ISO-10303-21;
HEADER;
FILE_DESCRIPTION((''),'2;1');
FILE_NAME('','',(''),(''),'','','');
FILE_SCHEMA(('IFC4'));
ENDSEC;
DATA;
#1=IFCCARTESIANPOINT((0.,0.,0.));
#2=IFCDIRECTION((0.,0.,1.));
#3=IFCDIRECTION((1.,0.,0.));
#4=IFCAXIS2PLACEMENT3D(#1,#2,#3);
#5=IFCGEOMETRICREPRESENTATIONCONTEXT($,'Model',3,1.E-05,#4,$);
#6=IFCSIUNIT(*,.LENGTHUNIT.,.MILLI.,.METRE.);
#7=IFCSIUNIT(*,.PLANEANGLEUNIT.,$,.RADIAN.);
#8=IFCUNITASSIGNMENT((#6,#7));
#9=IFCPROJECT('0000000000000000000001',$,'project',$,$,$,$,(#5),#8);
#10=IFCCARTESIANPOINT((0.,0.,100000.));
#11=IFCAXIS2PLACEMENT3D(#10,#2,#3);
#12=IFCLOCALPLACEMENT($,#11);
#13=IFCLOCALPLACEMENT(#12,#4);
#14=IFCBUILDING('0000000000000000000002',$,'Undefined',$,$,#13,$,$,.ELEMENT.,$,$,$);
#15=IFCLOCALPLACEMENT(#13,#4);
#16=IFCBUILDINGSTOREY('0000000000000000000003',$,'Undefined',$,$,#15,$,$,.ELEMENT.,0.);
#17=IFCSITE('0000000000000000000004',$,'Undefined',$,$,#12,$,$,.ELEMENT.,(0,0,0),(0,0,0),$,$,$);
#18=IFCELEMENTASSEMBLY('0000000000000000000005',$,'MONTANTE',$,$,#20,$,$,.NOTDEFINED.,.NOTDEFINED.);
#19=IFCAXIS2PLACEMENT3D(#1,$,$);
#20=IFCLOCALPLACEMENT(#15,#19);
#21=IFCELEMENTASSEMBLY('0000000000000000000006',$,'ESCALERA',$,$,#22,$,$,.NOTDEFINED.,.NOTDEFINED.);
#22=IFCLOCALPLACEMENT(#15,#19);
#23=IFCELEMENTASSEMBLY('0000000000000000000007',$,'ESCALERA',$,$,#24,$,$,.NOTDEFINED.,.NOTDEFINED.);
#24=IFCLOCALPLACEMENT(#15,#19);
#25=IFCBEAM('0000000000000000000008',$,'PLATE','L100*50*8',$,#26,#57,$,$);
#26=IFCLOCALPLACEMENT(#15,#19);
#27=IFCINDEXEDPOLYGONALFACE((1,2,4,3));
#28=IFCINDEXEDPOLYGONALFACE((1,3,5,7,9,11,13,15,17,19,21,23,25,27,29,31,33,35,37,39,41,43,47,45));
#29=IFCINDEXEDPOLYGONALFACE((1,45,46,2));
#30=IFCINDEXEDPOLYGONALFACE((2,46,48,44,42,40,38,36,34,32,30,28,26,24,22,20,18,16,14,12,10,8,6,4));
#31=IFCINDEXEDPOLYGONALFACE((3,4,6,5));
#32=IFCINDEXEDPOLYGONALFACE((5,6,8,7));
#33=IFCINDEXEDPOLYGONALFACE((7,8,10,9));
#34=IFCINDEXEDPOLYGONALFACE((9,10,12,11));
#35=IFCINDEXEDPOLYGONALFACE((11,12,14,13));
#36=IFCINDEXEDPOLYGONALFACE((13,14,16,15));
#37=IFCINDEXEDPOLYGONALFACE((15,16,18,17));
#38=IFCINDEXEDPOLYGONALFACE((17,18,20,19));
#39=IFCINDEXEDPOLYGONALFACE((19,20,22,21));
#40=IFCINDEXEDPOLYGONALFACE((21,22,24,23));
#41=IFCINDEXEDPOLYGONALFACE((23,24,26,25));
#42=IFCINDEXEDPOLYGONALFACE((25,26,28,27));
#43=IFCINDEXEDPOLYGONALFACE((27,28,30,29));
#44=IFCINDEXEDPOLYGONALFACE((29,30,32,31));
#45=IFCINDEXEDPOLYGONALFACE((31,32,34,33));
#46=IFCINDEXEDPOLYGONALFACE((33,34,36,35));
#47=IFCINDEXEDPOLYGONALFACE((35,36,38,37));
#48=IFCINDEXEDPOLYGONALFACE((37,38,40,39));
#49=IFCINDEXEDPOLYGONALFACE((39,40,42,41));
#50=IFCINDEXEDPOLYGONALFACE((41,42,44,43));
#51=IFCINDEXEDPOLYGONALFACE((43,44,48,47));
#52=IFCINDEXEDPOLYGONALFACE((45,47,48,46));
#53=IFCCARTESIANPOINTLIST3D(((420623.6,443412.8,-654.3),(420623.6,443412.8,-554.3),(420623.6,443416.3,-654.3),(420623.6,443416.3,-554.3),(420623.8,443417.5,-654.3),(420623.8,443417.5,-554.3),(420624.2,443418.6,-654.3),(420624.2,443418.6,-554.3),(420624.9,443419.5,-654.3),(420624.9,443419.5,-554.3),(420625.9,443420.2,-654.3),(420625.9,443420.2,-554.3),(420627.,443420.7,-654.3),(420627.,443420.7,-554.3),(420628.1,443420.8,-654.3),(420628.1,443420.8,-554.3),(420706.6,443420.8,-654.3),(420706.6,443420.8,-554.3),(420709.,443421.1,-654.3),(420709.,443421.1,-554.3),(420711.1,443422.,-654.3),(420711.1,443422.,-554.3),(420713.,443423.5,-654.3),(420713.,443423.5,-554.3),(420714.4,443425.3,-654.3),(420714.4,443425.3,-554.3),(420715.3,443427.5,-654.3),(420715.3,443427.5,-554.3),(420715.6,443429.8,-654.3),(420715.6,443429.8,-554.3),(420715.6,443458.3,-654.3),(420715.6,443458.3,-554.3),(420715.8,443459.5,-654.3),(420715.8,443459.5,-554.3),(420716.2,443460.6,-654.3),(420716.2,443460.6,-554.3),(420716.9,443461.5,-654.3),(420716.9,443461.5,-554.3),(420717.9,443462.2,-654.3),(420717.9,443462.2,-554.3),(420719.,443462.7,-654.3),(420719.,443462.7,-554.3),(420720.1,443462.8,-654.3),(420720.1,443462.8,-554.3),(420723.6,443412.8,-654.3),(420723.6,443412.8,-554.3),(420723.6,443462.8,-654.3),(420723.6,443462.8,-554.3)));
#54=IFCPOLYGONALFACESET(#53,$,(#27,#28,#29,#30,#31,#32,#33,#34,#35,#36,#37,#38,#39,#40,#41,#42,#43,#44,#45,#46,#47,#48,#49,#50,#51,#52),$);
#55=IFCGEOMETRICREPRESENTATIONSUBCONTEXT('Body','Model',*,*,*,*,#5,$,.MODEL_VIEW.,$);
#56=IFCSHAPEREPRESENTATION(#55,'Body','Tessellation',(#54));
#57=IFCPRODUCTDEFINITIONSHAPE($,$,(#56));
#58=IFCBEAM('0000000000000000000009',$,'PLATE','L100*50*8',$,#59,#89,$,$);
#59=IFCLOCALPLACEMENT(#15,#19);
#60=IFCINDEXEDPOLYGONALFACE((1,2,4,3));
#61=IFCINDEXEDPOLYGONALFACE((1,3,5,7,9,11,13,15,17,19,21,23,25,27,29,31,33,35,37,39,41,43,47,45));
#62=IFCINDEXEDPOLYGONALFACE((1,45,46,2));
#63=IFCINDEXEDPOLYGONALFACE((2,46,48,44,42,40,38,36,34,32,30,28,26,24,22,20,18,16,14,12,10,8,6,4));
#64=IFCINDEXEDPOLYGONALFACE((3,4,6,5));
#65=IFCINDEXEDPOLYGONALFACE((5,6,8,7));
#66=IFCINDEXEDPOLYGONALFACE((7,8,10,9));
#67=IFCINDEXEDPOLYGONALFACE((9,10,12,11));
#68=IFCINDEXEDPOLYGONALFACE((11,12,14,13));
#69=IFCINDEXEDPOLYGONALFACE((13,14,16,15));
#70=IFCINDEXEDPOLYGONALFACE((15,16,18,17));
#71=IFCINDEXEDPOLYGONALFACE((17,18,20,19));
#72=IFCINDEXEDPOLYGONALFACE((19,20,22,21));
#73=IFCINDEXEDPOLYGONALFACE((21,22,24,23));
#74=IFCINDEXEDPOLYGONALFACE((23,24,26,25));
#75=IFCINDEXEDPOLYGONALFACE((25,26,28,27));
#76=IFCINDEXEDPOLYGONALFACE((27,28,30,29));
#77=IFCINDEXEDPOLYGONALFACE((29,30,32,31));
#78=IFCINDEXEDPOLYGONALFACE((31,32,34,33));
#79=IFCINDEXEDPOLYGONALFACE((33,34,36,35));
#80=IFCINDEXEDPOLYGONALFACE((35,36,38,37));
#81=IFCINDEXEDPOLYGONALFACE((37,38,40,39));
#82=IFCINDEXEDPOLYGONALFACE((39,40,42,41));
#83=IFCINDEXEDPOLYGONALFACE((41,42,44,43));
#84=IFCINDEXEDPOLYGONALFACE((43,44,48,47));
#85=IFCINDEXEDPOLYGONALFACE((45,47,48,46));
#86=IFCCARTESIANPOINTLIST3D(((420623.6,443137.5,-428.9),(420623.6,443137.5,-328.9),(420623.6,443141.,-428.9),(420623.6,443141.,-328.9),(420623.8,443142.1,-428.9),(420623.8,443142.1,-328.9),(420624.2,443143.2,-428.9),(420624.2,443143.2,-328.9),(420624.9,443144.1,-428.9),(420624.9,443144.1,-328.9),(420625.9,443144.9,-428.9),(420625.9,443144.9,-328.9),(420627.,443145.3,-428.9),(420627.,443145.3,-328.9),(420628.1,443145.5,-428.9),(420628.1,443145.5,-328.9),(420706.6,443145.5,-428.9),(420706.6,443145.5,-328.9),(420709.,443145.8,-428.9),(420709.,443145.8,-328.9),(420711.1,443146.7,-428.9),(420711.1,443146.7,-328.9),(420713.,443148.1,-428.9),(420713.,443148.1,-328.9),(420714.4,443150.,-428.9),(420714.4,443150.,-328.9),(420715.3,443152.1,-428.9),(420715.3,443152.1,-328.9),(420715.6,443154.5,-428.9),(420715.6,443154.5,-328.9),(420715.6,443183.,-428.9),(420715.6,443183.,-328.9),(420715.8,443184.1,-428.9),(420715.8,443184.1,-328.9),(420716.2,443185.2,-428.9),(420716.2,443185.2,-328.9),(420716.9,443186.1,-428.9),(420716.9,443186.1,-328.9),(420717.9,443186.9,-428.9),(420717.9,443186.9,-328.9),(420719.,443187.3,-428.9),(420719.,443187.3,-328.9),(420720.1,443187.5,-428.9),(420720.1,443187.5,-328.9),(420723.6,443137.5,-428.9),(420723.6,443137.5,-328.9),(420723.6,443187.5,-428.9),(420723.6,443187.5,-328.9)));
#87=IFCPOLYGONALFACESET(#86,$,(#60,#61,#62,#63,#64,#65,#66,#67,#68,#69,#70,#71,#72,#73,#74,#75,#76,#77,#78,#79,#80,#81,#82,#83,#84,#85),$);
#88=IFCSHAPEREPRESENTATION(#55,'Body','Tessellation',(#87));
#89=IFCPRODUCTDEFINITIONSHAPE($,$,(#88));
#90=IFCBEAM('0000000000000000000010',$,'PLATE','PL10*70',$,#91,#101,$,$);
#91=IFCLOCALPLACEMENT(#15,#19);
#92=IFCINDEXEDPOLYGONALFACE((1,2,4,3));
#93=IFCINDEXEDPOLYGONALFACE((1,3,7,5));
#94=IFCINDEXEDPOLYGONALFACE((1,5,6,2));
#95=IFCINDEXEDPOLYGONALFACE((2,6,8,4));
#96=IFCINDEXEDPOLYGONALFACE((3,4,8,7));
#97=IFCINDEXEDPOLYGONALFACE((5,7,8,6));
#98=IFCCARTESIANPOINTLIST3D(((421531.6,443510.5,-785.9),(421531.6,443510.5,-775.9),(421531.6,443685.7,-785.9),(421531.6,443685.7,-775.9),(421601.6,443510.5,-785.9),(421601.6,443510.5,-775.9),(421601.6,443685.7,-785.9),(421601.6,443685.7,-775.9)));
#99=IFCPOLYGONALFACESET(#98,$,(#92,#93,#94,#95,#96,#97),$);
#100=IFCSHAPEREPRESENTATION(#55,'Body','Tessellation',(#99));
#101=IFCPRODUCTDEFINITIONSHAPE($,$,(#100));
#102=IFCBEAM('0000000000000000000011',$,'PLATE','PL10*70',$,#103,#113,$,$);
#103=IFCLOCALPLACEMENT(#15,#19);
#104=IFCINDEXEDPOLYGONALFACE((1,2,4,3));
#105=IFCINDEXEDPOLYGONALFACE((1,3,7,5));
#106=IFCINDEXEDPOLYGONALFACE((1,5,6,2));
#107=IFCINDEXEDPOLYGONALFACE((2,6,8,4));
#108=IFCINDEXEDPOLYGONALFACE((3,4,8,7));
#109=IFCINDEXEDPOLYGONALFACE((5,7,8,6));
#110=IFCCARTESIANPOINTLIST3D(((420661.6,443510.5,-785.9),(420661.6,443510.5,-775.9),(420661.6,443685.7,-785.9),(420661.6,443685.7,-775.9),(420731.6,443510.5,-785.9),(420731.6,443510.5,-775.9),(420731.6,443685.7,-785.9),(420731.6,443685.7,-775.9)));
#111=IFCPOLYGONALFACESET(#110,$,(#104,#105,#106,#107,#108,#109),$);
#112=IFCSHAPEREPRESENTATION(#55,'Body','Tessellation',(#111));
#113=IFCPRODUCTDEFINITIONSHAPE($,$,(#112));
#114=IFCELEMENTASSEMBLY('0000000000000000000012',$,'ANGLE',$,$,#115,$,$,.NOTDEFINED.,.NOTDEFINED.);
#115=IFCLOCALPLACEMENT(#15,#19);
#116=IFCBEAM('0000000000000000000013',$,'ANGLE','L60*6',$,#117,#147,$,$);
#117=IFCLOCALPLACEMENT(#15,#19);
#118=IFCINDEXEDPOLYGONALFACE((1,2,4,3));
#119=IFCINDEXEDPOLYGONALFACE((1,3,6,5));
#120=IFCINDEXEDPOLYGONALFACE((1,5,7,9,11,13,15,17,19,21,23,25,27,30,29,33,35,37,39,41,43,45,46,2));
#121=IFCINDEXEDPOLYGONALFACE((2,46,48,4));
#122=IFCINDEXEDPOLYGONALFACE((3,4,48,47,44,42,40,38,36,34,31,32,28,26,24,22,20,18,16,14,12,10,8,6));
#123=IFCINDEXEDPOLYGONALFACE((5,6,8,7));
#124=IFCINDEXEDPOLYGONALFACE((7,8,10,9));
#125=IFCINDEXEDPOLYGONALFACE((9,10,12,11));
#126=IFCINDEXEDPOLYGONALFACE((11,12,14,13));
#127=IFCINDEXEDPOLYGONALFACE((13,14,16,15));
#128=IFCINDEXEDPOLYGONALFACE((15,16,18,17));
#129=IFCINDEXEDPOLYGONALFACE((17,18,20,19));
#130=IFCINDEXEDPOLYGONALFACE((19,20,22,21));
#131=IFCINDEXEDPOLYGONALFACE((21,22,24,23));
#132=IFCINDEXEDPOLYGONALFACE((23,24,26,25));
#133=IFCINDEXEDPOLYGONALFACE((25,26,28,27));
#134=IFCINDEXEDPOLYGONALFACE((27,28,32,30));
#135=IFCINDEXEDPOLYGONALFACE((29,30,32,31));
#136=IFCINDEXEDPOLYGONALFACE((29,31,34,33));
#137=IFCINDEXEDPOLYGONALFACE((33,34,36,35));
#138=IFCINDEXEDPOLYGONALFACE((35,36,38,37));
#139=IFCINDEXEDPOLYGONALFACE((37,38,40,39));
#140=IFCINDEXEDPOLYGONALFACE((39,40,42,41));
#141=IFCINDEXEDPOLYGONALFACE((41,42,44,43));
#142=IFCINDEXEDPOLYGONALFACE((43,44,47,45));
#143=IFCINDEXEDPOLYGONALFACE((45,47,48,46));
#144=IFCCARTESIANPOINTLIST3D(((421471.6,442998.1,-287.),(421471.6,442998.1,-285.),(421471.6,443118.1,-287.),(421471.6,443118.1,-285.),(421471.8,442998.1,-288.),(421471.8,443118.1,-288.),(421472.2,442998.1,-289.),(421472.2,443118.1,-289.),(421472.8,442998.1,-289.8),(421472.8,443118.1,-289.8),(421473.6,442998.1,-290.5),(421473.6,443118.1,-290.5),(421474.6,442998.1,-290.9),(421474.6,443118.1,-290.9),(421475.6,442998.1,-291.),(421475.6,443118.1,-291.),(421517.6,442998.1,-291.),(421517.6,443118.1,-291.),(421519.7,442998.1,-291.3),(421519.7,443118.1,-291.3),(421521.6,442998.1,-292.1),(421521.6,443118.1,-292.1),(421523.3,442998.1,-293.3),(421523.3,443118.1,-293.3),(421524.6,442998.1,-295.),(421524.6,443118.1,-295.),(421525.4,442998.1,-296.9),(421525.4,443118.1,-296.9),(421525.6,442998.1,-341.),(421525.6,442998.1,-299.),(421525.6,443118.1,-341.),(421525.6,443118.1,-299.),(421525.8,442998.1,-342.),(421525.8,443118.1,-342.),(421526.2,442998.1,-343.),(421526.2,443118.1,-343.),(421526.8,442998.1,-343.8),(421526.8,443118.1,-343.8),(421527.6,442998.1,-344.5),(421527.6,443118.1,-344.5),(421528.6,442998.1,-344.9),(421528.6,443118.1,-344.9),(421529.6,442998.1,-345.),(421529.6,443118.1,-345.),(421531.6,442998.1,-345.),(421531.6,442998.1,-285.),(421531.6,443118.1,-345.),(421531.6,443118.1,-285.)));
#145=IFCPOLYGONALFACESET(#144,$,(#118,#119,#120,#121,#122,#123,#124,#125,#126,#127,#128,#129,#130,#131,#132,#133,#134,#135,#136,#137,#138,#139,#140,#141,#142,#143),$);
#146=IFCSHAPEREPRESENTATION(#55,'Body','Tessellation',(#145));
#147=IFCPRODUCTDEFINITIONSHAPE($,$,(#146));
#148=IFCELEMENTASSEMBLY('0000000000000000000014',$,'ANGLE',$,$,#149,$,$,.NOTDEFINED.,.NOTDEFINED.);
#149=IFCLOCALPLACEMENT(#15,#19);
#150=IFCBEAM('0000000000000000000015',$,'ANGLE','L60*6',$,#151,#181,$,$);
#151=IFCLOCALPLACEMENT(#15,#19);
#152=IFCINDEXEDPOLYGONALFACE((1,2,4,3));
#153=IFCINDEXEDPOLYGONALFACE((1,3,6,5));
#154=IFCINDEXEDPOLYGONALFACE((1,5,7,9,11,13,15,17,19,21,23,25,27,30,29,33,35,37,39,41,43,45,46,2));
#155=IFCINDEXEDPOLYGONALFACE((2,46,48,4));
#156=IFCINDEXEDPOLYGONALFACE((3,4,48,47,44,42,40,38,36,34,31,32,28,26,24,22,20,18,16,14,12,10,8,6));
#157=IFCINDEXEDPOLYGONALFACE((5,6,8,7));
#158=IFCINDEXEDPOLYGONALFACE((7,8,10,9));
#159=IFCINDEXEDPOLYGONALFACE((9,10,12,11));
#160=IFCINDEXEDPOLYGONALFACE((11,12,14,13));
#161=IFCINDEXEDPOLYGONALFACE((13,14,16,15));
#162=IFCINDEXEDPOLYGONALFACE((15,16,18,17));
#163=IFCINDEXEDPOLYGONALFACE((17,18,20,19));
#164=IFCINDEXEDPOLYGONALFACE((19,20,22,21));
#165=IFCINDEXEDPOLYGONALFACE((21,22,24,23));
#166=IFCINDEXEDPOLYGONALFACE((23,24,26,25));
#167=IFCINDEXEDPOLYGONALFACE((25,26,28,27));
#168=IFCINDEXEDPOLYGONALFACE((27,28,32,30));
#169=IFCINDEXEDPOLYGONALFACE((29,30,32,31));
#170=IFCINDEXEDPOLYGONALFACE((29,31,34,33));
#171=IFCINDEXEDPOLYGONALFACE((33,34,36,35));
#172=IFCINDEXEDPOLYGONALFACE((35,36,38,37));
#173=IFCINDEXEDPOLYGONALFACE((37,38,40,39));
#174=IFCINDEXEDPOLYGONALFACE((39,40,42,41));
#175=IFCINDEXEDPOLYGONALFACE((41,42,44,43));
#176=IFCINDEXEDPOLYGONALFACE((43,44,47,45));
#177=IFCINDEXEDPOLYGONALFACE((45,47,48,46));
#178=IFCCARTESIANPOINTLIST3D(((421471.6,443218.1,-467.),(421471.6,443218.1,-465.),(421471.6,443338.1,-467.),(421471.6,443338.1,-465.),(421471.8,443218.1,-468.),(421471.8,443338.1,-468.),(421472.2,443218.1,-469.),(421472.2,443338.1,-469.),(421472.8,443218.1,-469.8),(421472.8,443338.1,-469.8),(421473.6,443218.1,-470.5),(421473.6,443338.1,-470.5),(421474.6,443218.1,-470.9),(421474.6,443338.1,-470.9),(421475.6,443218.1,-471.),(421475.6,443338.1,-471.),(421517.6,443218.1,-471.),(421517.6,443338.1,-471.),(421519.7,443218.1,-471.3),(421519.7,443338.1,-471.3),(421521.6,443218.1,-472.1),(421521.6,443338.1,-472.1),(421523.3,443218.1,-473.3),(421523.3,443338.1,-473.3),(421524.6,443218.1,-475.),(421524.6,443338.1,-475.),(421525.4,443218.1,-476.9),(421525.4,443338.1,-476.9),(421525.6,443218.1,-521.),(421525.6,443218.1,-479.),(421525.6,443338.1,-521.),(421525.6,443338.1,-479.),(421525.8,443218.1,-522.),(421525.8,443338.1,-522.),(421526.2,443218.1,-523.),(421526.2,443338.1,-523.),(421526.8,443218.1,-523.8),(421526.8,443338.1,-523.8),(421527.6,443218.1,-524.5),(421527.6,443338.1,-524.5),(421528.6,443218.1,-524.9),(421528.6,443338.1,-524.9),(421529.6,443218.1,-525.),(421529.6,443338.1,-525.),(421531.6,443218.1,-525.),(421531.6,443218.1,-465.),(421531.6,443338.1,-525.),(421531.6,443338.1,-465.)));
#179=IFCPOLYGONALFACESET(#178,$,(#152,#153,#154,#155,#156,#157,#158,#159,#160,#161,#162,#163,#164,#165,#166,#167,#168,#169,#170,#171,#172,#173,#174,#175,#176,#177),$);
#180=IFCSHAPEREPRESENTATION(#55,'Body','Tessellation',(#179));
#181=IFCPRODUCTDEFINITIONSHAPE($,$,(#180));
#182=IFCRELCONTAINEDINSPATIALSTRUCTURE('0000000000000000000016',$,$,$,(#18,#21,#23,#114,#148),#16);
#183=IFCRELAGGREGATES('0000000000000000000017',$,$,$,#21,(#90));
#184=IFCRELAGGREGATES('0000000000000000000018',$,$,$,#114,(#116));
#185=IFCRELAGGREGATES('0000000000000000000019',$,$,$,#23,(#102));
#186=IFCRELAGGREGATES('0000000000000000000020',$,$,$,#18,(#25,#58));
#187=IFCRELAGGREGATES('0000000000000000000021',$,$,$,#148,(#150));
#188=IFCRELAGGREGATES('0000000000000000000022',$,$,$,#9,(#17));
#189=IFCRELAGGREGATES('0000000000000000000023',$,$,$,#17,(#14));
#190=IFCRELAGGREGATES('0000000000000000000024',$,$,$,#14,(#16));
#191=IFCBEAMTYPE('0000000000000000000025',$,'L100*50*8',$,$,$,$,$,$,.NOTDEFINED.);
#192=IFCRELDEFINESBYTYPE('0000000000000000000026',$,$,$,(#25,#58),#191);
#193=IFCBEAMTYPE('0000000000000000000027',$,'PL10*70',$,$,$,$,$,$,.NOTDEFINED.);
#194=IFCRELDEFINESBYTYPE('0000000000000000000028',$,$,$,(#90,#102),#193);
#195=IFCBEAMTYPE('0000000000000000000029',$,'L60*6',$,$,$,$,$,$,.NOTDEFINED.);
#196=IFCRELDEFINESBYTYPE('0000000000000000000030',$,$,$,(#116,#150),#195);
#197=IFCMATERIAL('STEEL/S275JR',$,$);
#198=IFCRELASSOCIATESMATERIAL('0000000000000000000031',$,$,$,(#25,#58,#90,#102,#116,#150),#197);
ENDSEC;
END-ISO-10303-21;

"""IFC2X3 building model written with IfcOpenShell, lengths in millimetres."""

from ifc_helpers import new_model, si_unit, frame, origin_with_axes, origin_2d_with_axis, place, context, subcontext, project, spatial, rectangle, l_section, extrude, material, type_object, element, aggregate, save


model = new_model("IFC2X3")

# Units and contexts
model_context = context("Model", 3, precision=1e-05, world=origin_with_axes())
body_context = subcontext(model_context, "Body", "Model", "MODEL_VIEW")
ifc_project = project(units=[si_unit("LENGTHUNIT", "METRE", prefix="MILLI"), si_unit("PLANEANGLEUNIT", "RADIAN")], contexts=[model_context])

# Site, building, storey
site_placement = place(None, frame((0.0, 0.0, 100000.0), z_axis=(0.0, 0.0, 1.0), x_axis=(1.0, 0.0, 0.0)))
site = spatial("IfcSite", under=ifc_project, at=site_placement, Name="Undefined", CompositionType="ELEMENT", RefLatitude=(0, 0, 0), RefLongitude=(0, 0, 0))
building_placement = place(site_placement, origin_with_axes())
building = spatial("IfcBuilding", under=site, at=building_placement, Name="Undefined", CompositionType="ELEMENT")
storey_placement = place(building_placement, origin_with_axes())
storey = spatial("IfcBuildingStorey", under=building, at=storey_placement, Name="Undefined", CompositionType="ELEMENT", Elevation=0.0)

# Element assemblies
assembly_1_placement = place(storey_placement, origin_with_axes())
assembly_1 = element("IfcElementAssembly", 1, at=assembly_1_placement, inside=storey, Name="MONTANTE", AssemblyPlace="NOTDEFINED", PredefinedType="NOTDEFINED")
assembly_2_placement = place(storey_placement, origin_with_axes())
assembly_2 = element("IfcElementAssembly", 2, at=assembly_2_placement, inside=storey, Name="ESCALERA", AssemblyPlace="NOTDEFINED", PredefinedType="NOTDEFINED")
ifc_material_1 = material(Name="STEEL/S275JR")
assembly_3_placement = place(storey_placement, origin_with_axes())
assembly_3 = element("IfcElementAssembly", 3, at=assembly_3_placement, inside=storey, Name="ESCALERA", AssemblyPlace="NOTDEFINED", PredefinedType="NOTDEFINED")

# Beams
beam_type_1 = type_object("IfcBeamType", Name="L100*50*8", PredefinedType="NOTDEFINED")
beam_1_placement = place(assembly_1_placement, frame((420673.6, 443437.8, -554.3), z_axis=(-1.0, -0.000001, 0.0), x_axis=(0.0, 0.0, -1.0)))
beam_1 = element("IfcBeam", 4, at=beam_1_placement, type_object=beam_type_1, material=ifc_material_1, Name="PLATE", Description="L100*50*8", context=body_context, shape_type="SweptSolid", body=[
    extrude(l_section(Depth=100.0, Width=50.0, Thickness=8.0, FilletRadius=9.0, EdgeRadius=4.5, at=origin_2d_with_axis()), frame((100.0, 0.0, 0.0), z_axis=(-1.0, 0.0, 0.0), x_axis=(0.0, -1.0, 0.0)), (0.0, 0.0, 1.0), 100.0),
])
beam_2_placement = place(assembly_1_placement, frame((420673.6, 443162.5, -328.9), z_axis=(-1.0, -0.000001, 0.0), x_axis=(0.0, 0.0, -1.0)))
beam_2 = element("IfcBeam", 5, at=beam_2_placement, type_object=beam_type_1, material=ifc_material_1, Name="PLATE", Description="L100*50*8", context=body_context, shape_type="SweptSolid", body=[
    extrude(l_section(Depth=100.0, Width=50.0, Thickness=8.0, FilletRadius=9.0, EdgeRadius=4.5, at=origin_2d_with_axis()), frame((100.0, 0.0, 0.0), z_axis=(-1.0, 0.0, 0.0), x_axis=(0.0, -1.0, 0.0)), (0.0, 0.0, 1.0), 100.0),
])
beam_type_2 = type_object("IfcBeamType", Name="PL10*70", PredefinedType="NOTDEFINED")
beam_3_placement = place(assembly_2_placement, frame((421566.6, 443510.5, -780.9), z_axis=(-1.0, -0.000001, 0.0), x_axis=(-0.000001, 1.0, 0.0)))
beam_3 = element("IfcBeam", 6, at=beam_3_placement, type_object=beam_type_2, material=ifc_material_1, Name="PLATE", Description="PL10*70", context=body_context, shape_type="SweptSolid", body=[
    extrude(rectangle(XDim=10.0, YDim=70.0, at=origin_2d_with_axis()), frame((175.3, 0.0, 0.0), z_axis=(-1.0, 0.0, 0.0), x_axis=(0.0, -1.0, 0.0)), (0.0, 0.0, 1.0), 175.2),
])
aggregate(assembly_2, [beam_3])
beam_4_placement = place(assembly_3_placement, frame((420696.6, 443510.5, -780.9), z_axis=(-1.0, -0.000001, 0.0), x_axis=(-0.000001, 1.0, 0.0)))
beam_4 = element("IfcBeam", 7, at=beam_4_placement, type_object=beam_type_2, material=ifc_material_1, Name="PLATE", Description="PL10*70", context=body_context, shape_type="SweptSolid", body=[
    extrude(rectangle(XDim=10.0, YDim=70.0, at=origin_2d_with_axis()), frame((175.3, 0.0, 0.0), z_axis=(-1.0, 0.0, 0.0), x_axis=(0.0, -1.0, 0.0)), (0.0, 0.0, 1.0), 175.2),
])

# Element assemblies, beams
assembly_4_placement = place(storey_placement, origin_with_axes())
assembly_4 = element("IfcElementAssembly", 8, at=assembly_4_placement, inside=storey, Name="ANGLE", AssemblyPlace="NOTDEFINED", PredefinedType="NOTDEFINED")
beam_type_3 = type_object("IfcBeamType", Name="L60*6", PredefinedType="NOTDEFINED")
beam_5_placement = place(assembly_4_placement, frame((421501.6, 443118.1, -315.0), z_axis=(-1.0, -0.000001, 0.0), x_axis=(0.000001, -1.0, 0.0)))
beam_5 = element("IfcBeam", 9, at=beam_5_placement, type_object=beam_type_3, material=ifc_material_1, Name="ANGLE", Description="L60*6", context=body_context, shape_type="SweptSolid", body=[
    extrude(l_section(Depth=60.0, Width=60.0, Thickness=6.0, FilletRadius=8.0, EdgeRadius=4.0, at=origin_2d_with_axis()), frame((120.0, 0.0, 0.0), z_axis=(-1.0, 0.0, 0.0), x_axis=(0.0, -1.0, 0.0)), (0.0, 0.0, 1.0), 120.0),
])
aggregate(assembly_4, [beam_5])
assembly_5_placement = place(storey_placement, origin_with_axes())
assembly_5 = element("IfcElementAssembly", 10, at=assembly_5_placement, inside=storey, Name="ANGLE", AssemblyPlace="NOTDEFINED", PredefinedType="NOTDEFINED")
beam_6_placement = place(assembly_5_placement, frame((421501.6, 443338.1, -495.0), z_axis=(-1.0, -0.000001, 0.0), x_axis=(0.000001, -1.0, 0.0)))
beam_6 = element("IfcBeam", 11, at=beam_6_placement, type_object=beam_type_3, material=ifc_material_1, Name="ANGLE", Description="L60*6", context=body_context, shape_type="SweptSolid", body=[
    extrude(l_section(Depth=60.0, Width=60.0, Thickness=6.0, FilletRadius=8.0, EdgeRadius=4.0, at=origin_2d_with_axis()), frame((120.0, 0.0, 0.0), z_axis=(-1.0, 0.0, 0.0), x_axis=(0.0, -1.0, 0.0)), (0.0, 0.0, 1.0), 120.0),
])

aggregate(assembly_3, [beam_4])

aggregate(assembly_1, [beam_1, beam_2])
aggregate(assembly_5, [beam_6])

save(model, "model.ifc")
